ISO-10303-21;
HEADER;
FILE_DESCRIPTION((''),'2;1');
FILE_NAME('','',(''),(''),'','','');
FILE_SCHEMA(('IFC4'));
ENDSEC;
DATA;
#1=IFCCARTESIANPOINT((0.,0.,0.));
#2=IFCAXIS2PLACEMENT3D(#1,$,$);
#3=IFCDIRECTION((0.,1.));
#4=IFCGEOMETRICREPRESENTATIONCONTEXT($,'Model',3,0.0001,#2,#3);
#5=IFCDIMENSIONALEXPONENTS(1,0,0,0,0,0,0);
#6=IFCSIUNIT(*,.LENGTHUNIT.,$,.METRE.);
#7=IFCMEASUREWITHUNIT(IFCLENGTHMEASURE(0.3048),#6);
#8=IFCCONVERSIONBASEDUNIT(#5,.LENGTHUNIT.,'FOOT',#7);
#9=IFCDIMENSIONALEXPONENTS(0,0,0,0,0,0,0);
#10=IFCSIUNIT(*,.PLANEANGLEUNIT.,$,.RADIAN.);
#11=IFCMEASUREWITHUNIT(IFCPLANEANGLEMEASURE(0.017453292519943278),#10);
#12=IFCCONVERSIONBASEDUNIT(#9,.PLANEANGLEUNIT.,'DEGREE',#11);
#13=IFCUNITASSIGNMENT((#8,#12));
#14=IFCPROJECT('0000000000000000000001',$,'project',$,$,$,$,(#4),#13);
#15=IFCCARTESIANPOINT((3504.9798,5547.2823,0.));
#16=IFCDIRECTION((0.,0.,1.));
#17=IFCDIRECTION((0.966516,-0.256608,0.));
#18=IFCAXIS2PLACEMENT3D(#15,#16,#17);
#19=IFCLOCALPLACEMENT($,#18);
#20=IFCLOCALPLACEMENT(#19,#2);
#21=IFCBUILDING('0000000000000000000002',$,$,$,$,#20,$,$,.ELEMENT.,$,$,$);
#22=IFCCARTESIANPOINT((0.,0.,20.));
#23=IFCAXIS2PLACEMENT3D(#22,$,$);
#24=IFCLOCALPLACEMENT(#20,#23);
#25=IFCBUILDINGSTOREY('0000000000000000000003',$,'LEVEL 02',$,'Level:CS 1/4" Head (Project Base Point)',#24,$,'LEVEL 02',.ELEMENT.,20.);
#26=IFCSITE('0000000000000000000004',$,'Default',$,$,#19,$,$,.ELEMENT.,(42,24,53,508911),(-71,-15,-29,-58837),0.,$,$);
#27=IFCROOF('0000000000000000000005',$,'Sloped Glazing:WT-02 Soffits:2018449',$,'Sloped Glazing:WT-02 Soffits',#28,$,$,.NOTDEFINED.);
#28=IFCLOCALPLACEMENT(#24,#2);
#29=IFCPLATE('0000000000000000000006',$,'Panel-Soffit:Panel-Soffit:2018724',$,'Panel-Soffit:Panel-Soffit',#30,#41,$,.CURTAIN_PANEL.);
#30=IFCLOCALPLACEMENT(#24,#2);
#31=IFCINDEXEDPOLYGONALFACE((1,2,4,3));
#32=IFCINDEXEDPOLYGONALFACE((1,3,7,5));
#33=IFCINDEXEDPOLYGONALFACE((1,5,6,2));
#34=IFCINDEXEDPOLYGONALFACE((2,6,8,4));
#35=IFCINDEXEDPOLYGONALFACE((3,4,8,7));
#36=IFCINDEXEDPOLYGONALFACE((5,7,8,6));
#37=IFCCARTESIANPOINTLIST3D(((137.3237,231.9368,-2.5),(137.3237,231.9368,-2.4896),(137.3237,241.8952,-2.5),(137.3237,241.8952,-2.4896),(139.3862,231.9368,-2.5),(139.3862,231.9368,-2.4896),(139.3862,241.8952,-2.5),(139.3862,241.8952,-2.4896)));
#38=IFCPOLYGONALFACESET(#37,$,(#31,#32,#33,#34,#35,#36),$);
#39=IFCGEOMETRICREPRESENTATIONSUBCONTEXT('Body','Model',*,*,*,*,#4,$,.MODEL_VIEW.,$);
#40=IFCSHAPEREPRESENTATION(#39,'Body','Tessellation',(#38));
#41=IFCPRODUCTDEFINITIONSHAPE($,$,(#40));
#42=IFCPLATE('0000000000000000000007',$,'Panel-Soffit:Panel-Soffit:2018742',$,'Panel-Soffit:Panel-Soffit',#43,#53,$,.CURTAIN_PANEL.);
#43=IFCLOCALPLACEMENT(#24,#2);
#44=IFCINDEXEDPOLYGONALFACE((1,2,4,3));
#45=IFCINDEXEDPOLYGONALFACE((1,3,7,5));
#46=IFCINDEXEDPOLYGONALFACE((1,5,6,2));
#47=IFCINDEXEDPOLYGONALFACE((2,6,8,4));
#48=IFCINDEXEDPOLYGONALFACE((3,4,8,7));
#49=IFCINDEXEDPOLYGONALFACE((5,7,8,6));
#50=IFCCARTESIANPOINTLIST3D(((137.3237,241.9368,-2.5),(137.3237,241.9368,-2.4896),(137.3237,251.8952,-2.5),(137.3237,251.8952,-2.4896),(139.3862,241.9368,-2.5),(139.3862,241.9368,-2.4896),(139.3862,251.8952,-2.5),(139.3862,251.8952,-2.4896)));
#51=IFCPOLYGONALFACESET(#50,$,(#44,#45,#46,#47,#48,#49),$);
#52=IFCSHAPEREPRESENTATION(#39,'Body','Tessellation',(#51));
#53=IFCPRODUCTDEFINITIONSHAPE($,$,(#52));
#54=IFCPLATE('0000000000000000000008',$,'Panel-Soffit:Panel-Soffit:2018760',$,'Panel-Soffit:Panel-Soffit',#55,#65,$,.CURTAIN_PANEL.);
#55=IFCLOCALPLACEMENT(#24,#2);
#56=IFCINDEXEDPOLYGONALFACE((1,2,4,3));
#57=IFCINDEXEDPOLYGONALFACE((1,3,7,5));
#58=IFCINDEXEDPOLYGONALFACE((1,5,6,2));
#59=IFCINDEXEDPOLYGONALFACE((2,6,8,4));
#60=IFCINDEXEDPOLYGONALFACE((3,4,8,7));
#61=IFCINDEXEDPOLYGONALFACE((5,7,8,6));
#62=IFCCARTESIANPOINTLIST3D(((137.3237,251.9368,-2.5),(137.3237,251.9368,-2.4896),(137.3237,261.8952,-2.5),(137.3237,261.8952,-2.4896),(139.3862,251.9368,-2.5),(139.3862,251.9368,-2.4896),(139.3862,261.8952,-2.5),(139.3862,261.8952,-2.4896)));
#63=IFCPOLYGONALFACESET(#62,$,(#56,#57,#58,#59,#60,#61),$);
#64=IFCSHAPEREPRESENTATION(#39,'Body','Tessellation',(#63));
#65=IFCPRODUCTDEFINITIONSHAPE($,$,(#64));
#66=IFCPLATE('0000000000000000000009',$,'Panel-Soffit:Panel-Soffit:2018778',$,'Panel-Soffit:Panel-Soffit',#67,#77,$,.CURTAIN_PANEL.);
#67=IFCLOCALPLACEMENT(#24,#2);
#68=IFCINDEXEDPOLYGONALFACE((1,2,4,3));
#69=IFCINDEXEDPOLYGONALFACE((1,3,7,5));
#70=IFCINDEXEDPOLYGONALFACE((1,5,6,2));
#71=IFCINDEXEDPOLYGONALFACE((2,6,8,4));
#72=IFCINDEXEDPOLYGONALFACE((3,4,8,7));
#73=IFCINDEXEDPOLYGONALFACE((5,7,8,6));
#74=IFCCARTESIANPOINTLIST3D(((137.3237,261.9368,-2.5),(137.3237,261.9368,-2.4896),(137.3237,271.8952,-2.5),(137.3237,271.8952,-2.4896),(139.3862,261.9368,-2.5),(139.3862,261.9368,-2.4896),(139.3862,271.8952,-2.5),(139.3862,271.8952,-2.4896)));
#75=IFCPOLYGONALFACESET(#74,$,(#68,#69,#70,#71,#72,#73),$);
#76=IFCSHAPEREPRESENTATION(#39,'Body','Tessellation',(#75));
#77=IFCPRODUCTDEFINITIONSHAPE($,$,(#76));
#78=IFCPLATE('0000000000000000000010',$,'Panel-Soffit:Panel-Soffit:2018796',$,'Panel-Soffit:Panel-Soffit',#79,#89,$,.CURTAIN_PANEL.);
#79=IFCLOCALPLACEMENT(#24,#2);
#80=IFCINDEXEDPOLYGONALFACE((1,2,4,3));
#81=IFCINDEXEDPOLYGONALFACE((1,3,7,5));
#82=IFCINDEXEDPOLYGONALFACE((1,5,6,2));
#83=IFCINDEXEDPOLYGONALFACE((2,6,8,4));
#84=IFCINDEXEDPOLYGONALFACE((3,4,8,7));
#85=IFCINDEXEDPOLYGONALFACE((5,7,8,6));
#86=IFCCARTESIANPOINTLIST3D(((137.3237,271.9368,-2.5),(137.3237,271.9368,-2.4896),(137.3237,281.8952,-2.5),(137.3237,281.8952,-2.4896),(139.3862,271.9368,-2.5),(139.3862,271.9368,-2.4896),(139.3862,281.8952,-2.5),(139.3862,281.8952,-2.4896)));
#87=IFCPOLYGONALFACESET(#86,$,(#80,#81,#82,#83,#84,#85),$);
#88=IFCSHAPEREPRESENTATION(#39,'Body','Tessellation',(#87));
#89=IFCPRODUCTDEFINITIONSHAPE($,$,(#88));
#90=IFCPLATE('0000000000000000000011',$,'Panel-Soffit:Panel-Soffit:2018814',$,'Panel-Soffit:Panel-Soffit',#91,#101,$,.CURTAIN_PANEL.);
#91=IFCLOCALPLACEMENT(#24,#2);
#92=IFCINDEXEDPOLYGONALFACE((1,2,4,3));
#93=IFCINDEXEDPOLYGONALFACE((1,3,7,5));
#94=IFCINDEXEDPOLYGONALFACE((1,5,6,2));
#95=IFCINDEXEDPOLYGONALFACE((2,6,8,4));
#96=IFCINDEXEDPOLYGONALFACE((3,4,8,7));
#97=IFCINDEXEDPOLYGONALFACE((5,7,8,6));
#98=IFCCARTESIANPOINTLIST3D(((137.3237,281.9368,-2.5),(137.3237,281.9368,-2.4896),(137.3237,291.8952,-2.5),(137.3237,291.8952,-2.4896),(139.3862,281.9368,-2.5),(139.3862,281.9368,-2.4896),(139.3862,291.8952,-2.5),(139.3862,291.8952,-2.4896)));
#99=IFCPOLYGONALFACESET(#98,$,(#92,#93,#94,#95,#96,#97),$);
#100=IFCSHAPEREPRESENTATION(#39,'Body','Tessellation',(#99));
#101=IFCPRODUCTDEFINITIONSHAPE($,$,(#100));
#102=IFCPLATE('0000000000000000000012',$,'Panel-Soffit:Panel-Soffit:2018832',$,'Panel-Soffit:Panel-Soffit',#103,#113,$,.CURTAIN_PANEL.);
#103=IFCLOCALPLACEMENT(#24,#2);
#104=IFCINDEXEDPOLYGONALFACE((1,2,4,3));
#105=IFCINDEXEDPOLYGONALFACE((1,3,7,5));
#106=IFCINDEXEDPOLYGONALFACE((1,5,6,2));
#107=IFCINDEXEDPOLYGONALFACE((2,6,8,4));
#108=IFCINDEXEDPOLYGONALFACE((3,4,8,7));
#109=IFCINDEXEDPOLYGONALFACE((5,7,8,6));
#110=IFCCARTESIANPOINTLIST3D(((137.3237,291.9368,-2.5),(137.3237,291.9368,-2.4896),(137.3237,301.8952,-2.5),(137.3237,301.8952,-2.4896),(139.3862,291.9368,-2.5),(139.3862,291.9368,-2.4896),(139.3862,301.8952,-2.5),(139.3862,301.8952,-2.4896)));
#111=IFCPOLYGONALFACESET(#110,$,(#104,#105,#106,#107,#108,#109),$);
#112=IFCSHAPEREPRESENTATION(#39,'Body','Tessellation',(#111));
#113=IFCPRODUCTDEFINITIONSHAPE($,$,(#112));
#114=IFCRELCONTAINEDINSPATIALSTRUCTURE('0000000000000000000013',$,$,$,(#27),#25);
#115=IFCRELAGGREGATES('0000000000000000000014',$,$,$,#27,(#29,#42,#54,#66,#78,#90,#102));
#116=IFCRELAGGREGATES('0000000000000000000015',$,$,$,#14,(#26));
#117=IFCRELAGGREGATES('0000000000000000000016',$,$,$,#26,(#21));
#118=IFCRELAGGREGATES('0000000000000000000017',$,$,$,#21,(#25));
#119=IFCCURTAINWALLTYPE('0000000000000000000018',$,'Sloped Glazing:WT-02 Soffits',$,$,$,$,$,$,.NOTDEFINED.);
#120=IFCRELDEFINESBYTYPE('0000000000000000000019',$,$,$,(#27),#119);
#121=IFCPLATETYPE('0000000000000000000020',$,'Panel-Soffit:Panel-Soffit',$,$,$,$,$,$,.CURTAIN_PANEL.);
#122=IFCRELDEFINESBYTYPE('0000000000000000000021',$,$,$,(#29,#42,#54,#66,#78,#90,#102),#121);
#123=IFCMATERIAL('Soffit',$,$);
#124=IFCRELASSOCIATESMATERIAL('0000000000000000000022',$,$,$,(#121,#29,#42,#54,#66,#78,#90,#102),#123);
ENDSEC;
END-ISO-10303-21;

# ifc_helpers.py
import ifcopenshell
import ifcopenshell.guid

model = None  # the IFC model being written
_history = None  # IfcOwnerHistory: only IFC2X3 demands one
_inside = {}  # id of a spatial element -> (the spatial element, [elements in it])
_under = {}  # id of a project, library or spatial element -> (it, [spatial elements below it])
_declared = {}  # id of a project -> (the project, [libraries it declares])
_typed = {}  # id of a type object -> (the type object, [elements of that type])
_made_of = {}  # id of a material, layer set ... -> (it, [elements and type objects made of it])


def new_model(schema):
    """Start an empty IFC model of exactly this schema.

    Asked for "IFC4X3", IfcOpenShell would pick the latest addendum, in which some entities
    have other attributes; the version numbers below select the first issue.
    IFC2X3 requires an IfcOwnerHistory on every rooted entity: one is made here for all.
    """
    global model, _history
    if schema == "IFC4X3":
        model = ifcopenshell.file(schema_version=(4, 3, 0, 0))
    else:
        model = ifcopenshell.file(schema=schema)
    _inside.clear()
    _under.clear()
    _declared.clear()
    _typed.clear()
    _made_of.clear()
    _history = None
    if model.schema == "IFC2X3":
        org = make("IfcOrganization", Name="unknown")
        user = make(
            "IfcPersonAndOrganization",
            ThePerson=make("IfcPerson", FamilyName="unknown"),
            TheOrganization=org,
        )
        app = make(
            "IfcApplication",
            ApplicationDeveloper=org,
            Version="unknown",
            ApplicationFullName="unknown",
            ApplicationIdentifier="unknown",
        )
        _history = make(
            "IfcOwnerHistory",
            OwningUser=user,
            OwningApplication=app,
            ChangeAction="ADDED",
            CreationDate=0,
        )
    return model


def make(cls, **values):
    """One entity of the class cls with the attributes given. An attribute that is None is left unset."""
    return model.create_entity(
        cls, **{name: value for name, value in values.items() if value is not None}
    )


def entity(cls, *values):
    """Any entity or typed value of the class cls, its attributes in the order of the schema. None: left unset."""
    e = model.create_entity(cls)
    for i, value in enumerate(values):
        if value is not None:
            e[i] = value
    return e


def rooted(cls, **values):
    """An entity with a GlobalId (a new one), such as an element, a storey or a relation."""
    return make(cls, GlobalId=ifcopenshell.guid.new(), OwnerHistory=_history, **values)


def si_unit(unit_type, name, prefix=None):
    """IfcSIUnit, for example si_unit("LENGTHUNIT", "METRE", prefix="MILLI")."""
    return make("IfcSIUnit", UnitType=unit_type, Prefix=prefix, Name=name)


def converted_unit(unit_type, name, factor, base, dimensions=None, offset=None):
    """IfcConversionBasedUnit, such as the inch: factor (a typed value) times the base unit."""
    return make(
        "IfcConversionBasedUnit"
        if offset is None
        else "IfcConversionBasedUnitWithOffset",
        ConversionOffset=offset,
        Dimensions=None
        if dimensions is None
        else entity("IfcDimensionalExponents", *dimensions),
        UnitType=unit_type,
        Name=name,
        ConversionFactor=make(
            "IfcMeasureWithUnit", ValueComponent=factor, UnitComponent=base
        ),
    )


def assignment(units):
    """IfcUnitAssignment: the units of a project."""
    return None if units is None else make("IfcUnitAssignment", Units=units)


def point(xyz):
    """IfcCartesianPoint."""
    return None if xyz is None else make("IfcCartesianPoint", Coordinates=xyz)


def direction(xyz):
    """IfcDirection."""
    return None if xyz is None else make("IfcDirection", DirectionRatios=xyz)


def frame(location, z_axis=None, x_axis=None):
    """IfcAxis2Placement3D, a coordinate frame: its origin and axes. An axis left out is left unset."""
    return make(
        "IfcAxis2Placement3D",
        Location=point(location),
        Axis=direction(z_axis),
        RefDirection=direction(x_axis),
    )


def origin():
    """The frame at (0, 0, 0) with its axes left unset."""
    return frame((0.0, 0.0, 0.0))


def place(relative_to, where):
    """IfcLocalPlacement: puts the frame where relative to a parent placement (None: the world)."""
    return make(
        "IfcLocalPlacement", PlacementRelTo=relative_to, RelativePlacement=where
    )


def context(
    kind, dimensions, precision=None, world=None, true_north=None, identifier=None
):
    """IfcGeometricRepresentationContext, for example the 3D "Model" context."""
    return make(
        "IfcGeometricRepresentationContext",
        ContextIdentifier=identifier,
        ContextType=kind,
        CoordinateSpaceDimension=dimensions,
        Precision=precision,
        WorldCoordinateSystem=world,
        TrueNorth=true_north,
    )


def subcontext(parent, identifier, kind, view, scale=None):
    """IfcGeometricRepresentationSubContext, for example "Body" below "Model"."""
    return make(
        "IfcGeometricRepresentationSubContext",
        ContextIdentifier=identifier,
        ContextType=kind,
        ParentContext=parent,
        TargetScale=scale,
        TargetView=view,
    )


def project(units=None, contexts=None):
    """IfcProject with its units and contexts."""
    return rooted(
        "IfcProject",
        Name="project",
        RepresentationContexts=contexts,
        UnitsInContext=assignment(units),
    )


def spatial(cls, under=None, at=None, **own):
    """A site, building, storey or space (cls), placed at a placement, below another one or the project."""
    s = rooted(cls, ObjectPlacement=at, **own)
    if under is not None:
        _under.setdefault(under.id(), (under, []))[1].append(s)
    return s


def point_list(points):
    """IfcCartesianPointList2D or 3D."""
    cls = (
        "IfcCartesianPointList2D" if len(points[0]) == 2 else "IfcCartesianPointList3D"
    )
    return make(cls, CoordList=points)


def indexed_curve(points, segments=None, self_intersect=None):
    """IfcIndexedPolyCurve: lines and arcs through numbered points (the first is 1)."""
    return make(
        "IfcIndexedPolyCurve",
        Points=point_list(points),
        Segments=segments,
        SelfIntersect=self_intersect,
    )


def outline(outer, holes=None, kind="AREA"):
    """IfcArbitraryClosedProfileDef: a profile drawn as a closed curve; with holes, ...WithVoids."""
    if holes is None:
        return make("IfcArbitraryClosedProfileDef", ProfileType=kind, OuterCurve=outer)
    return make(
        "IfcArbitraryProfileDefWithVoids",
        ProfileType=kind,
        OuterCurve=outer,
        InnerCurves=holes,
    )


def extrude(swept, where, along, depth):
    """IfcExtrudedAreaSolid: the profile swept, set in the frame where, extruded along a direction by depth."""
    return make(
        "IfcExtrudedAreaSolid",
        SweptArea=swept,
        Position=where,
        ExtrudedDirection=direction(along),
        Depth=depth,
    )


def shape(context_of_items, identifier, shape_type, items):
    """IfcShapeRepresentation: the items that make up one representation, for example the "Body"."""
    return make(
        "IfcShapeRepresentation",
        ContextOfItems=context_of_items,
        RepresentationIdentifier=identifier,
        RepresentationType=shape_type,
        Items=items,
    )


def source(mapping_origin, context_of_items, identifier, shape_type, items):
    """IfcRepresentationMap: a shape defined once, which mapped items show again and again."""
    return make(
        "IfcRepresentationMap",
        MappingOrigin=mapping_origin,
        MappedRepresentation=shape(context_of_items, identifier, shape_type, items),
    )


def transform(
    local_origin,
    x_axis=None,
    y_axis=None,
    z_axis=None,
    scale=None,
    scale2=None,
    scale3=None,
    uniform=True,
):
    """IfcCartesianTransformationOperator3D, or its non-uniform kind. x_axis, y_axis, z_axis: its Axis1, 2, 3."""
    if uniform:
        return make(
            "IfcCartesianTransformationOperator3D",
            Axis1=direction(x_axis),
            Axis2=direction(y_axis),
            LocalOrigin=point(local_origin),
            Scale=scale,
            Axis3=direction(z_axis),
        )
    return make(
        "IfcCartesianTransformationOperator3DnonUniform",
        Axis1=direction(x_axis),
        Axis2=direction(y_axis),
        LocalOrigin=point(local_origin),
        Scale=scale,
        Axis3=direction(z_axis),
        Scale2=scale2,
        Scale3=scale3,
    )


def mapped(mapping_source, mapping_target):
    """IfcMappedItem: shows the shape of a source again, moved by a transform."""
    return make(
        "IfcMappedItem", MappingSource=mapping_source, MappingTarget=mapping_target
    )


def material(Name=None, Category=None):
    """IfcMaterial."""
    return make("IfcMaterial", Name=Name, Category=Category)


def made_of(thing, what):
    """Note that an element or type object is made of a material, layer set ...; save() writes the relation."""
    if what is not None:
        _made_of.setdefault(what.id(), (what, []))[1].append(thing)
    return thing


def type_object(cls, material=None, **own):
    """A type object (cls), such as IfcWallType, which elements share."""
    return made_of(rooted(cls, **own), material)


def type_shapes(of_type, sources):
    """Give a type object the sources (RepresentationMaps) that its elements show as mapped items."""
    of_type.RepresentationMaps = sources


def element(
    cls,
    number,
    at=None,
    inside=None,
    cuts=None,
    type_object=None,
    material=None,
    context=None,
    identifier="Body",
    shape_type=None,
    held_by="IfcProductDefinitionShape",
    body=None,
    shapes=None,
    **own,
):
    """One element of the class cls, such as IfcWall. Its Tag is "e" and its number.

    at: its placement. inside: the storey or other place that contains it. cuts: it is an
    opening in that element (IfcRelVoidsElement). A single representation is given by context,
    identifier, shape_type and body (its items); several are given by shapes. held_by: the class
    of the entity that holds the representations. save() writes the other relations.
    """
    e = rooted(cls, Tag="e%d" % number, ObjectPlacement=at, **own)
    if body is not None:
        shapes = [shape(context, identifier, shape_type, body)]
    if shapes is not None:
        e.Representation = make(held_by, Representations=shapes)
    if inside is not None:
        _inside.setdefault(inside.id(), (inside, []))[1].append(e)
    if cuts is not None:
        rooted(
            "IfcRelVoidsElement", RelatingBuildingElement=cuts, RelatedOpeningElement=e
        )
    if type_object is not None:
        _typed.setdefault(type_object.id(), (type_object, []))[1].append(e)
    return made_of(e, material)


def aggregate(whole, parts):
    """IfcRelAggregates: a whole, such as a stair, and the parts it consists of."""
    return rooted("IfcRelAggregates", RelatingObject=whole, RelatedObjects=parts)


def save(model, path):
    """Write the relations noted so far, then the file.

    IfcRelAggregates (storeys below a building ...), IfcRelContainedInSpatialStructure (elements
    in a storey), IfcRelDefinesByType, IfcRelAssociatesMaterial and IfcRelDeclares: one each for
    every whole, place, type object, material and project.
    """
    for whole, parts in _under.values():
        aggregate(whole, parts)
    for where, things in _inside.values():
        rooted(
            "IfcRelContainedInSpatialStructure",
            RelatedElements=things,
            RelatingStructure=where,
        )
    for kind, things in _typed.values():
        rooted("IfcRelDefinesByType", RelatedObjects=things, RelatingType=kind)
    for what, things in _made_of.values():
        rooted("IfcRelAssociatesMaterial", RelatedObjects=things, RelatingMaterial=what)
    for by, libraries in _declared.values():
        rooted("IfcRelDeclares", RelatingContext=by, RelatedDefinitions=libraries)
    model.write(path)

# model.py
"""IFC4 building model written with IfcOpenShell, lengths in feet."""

from ifc_helpers import new_model, entity, si_unit, converted_unit, direction, frame, origin, place, context, subcontext, project, spatial, indexed_curve, outline, extrude, source, transform, mapped, material, type_object, type_shapes, element, aggregate, save


model = new_model("IFC4")

# Units and contexts
model_context = context("Model", 3, precision=0.0001, world=origin(), true_north=direction((0.0, 1.0)))
body_context = subcontext(model_context, "Body", "Model", "MODEL_VIEW")
ifc_project = project(units=[converted_unit("LENGTHUNIT", "FOOT", entity("IfcLengthMeasure", 0.3048), si_unit("LENGTHUNIT", "METRE"), dimensions=[1, 0, 0, 0, 0, 0, 0]), converted_unit("PLANEANGLEUNIT", "DEGREE", entity("IfcPlaneAngleMeasure", 0.017453292519943278), si_unit("PLANEANGLEUNIT", "RADIAN"), dimensions=[0, 0, 0, 0, 0, 0, 0])], contexts=[model_context])

# Site, building, storey
site_placement = place(None, frame((3504.9798, 5547.2823, 0.0), z_axis=(0.0, 0.0, 1.0), x_axis=(0.966516, -0.256608, 0.0)))
site = spatial("IfcSite", under=ifc_project, at=site_placement, Name="Default", CompositionType="ELEMENT", RefLatitude=(42, 24, 53, 508911), RefLongitude=(-71, -15, -29, -58837), RefElevation=0.0)
building_placement = place(site_placement, origin())
building = spatial("IfcBuilding", under=site, at=building_placement, CompositionType="ELEMENT")
storey_placement = place(building_placement, frame((0.0, 0.0, 20.0)))
storey = spatial("IfcBuildingStorey", under=building, at=storey_placement, Name="LEVEL 02", ObjectType="Level:CS 1/4\" Head (Project Base Point)", LongName="LEVEL 02", CompositionType="ELEMENT", Elevation=20.0)

# Roof, plates
curtain_wall_type_1 = type_object("IfcCurtainWallType", Name="Sloped Glazing:WT-02 Soffits", PredefinedType="NOTDEFINED")
roof_1_placement = place(storey_placement, frame((0.0, 0.0, -20.0)))
roof_1 = element("IfcRoof", 1, at=roof_1_placement, inside=storey, type_object=curtain_wall_type_1, Name="Sloped Glazing:WT-02 Soffits:2018449", ObjectType="Sloped Glazing:WT-02 Soffits", PredefinedType="NOTDEFINED")
ifc_material_1 = material(Name="Soffit")
plate_type_1 = type_object("IfcPlateType", Name="Panel-Soffit:Panel-Soffit", PredefinedType="CURTAIN_PANEL", material=ifc_material_1)
shared_shape_1 = source(origin(), body_context, "Body", "SweptSolid", [
    extrude(outline(indexed_curve([(-0.0052, -1.0313), (0.0052, -1.0313), (0.0052, 1.0313), (-0.0052, 1.0313), (-0.0052, -1.0313)], self_intersect=False)), frame((1.0313, 0.0052, 0.0), z_axis=(0.0, 0.0, 1.0), x_axis=(0.0, -1.0, 0.0)), (0.0, 0.0, 1.0), 9.9583),
])
type_shapes(plate_type_1, [shared_shape_1])
plate_1_placement = place(roof_1_placement, frame((137.3237, 231.9368, 17.5104), z_axis=(0.0, 1.0, 0.0), x_axis=(1.0, 0.0, 0.0)))
plate_1 = element("IfcPlate", 2, at=plate_1_placement, type_object=plate_type_1, material=ifc_material_1, Name="Panel-Soffit:Panel-Soffit:2018724", ObjectType="Panel-Soffit:Panel-Soffit", PredefinedType="CURTAIN_PANEL", context=body_context, shape_type="MappedRepresentation", body=[
    mapped(shared_shape_1, transform((0.0, 0.0, 0.0), scale=1.0)),
])
plate_2_placement = place(roof_1_placement, frame((137.3237, 241.9368, 17.5104), z_axis=(0.0, 1.0, 0.0), x_axis=(1.0, 0.0, 0.0)))
plate_2 = element("IfcPlate", 3, at=plate_2_placement, type_object=plate_type_1, material=ifc_material_1, Name="Panel-Soffit:Panel-Soffit:2018742", ObjectType="Panel-Soffit:Panel-Soffit", PredefinedType="CURTAIN_PANEL", context=body_context, shape_type="MappedRepresentation", body=[
    mapped(shared_shape_1, transform((0.0, 0.0, 0.0), scale=1.0)),
])
plate_3_placement = place(roof_1_placement, frame((137.3237, 251.9368, 17.5104), z_axis=(0.0, 1.0, 0.0), x_axis=(1.0, 0.0, 0.0)))
plate_3 = element("IfcPlate", 4, at=plate_3_placement, type_object=plate_type_1, material=ifc_material_1, Name="Panel-Soffit:Panel-Soffit:2018760", ObjectType="Panel-Soffit:Panel-Soffit", PredefinedType="CURTAIN_PANEL", context=body_context, shape_type="MappedRepresentation", body=[
    mapped(shared_shape_1, transform((0.0, 0.0, 0.0), scale=1.0)),
])
plate_4_placement = place(roof_1_placement, frame((137.3237, 261.9368, 17.5104), z_axis=(0.0, 1.0, 0.0), x_axis=(1.0, 0.0, 0.0)))
plate_4 = element("IfcPlate", 5, at=plate_4_placement, type_object=plate_type_1, material=ifc_material_1, Name="Panel-Soffit:Panel-Soffit:2018778", ObjectType="Panel-Soffit:Panel-Soffit", PredefinedType="CURTAIN_PANEL", context=body_context, shape_type="MappedRepresentation", body=[
    mapped(shared_shape_1, transform((0.0, 0.0, 0.0), scale=1.0)),
])
plate_5_placement = place(roof_1_placement, frame((137.3237, 271.9368, 17.5104), z_axis=(0.0, 1.0, 0.0), x_axis=(1.0, 0.0, 0.0)))
plate_5 = element("IfcPlate", 6, at=plate_5_placement, type_object=plate_type_1, material=ifc_material_1, Name="Panel-Soffit:Panel-Soffit:2018796", ObjectType="Panel-Soffit:Panel-Soffit", PredefinedType="CURTAIN_PANEL", context=body_context, shape_type="MappedRepresentation", body=[
    mapped(shared_shape_1, transform((0.0, 0.0, 0.0), scale=1.0)),
])
plate_6_placement = place(roof_1_placement, frame((137.3237, 281.9368, 17.5104), z_axis=(0.0, 1.0, 0.0), x_axis=(1.0, 0.0, 0.0)))
plate_6 = element("IfcPlate", 7, at=plate_6_placement, type_object=plate_type_1, material=ifc_material_1, Name="Panel-Soffit:Panel-Soffit:2018814", ObjectType="Panel-Soffit:Panel-Soffit", PredefinedType="CURTAIN_PANEL", context=body_context, shape_type="MappedRepresentation", body=[
    mapped(shared_shape_1, transform((0.0, 0.0, 0.0), scale=1.0)),
])
plate_7_placement = place(roof_1_placement, frame((137.3237, 291.9368, 17.5104), z_axis=(0.0, 1.0, 0.0), x_axis=(1.0, 0.0, 0.0)))
plate_7 = element("IfcPlate", 8, at=plate_7_placement, type_object=plate_type_1, material=ifc_material_1, Name="Panel-Soffit:Panel-Soffit:2018832", ObjectType="Panel-Soffit:Panel-Soffit", PredefinedType="CURTAIN_PANEL", context=body_context, shape_type="MappedRepresentation", body=[
    mapped(shared_shape_1, transform((0.0, 0.0, 0.0), scale=1.0)),
])
aggregate(roof_1, [plate_1, plate_2, plate_3, plate_4, plate_5, plate_6, plate_7])

save(model, "model.ifc")
